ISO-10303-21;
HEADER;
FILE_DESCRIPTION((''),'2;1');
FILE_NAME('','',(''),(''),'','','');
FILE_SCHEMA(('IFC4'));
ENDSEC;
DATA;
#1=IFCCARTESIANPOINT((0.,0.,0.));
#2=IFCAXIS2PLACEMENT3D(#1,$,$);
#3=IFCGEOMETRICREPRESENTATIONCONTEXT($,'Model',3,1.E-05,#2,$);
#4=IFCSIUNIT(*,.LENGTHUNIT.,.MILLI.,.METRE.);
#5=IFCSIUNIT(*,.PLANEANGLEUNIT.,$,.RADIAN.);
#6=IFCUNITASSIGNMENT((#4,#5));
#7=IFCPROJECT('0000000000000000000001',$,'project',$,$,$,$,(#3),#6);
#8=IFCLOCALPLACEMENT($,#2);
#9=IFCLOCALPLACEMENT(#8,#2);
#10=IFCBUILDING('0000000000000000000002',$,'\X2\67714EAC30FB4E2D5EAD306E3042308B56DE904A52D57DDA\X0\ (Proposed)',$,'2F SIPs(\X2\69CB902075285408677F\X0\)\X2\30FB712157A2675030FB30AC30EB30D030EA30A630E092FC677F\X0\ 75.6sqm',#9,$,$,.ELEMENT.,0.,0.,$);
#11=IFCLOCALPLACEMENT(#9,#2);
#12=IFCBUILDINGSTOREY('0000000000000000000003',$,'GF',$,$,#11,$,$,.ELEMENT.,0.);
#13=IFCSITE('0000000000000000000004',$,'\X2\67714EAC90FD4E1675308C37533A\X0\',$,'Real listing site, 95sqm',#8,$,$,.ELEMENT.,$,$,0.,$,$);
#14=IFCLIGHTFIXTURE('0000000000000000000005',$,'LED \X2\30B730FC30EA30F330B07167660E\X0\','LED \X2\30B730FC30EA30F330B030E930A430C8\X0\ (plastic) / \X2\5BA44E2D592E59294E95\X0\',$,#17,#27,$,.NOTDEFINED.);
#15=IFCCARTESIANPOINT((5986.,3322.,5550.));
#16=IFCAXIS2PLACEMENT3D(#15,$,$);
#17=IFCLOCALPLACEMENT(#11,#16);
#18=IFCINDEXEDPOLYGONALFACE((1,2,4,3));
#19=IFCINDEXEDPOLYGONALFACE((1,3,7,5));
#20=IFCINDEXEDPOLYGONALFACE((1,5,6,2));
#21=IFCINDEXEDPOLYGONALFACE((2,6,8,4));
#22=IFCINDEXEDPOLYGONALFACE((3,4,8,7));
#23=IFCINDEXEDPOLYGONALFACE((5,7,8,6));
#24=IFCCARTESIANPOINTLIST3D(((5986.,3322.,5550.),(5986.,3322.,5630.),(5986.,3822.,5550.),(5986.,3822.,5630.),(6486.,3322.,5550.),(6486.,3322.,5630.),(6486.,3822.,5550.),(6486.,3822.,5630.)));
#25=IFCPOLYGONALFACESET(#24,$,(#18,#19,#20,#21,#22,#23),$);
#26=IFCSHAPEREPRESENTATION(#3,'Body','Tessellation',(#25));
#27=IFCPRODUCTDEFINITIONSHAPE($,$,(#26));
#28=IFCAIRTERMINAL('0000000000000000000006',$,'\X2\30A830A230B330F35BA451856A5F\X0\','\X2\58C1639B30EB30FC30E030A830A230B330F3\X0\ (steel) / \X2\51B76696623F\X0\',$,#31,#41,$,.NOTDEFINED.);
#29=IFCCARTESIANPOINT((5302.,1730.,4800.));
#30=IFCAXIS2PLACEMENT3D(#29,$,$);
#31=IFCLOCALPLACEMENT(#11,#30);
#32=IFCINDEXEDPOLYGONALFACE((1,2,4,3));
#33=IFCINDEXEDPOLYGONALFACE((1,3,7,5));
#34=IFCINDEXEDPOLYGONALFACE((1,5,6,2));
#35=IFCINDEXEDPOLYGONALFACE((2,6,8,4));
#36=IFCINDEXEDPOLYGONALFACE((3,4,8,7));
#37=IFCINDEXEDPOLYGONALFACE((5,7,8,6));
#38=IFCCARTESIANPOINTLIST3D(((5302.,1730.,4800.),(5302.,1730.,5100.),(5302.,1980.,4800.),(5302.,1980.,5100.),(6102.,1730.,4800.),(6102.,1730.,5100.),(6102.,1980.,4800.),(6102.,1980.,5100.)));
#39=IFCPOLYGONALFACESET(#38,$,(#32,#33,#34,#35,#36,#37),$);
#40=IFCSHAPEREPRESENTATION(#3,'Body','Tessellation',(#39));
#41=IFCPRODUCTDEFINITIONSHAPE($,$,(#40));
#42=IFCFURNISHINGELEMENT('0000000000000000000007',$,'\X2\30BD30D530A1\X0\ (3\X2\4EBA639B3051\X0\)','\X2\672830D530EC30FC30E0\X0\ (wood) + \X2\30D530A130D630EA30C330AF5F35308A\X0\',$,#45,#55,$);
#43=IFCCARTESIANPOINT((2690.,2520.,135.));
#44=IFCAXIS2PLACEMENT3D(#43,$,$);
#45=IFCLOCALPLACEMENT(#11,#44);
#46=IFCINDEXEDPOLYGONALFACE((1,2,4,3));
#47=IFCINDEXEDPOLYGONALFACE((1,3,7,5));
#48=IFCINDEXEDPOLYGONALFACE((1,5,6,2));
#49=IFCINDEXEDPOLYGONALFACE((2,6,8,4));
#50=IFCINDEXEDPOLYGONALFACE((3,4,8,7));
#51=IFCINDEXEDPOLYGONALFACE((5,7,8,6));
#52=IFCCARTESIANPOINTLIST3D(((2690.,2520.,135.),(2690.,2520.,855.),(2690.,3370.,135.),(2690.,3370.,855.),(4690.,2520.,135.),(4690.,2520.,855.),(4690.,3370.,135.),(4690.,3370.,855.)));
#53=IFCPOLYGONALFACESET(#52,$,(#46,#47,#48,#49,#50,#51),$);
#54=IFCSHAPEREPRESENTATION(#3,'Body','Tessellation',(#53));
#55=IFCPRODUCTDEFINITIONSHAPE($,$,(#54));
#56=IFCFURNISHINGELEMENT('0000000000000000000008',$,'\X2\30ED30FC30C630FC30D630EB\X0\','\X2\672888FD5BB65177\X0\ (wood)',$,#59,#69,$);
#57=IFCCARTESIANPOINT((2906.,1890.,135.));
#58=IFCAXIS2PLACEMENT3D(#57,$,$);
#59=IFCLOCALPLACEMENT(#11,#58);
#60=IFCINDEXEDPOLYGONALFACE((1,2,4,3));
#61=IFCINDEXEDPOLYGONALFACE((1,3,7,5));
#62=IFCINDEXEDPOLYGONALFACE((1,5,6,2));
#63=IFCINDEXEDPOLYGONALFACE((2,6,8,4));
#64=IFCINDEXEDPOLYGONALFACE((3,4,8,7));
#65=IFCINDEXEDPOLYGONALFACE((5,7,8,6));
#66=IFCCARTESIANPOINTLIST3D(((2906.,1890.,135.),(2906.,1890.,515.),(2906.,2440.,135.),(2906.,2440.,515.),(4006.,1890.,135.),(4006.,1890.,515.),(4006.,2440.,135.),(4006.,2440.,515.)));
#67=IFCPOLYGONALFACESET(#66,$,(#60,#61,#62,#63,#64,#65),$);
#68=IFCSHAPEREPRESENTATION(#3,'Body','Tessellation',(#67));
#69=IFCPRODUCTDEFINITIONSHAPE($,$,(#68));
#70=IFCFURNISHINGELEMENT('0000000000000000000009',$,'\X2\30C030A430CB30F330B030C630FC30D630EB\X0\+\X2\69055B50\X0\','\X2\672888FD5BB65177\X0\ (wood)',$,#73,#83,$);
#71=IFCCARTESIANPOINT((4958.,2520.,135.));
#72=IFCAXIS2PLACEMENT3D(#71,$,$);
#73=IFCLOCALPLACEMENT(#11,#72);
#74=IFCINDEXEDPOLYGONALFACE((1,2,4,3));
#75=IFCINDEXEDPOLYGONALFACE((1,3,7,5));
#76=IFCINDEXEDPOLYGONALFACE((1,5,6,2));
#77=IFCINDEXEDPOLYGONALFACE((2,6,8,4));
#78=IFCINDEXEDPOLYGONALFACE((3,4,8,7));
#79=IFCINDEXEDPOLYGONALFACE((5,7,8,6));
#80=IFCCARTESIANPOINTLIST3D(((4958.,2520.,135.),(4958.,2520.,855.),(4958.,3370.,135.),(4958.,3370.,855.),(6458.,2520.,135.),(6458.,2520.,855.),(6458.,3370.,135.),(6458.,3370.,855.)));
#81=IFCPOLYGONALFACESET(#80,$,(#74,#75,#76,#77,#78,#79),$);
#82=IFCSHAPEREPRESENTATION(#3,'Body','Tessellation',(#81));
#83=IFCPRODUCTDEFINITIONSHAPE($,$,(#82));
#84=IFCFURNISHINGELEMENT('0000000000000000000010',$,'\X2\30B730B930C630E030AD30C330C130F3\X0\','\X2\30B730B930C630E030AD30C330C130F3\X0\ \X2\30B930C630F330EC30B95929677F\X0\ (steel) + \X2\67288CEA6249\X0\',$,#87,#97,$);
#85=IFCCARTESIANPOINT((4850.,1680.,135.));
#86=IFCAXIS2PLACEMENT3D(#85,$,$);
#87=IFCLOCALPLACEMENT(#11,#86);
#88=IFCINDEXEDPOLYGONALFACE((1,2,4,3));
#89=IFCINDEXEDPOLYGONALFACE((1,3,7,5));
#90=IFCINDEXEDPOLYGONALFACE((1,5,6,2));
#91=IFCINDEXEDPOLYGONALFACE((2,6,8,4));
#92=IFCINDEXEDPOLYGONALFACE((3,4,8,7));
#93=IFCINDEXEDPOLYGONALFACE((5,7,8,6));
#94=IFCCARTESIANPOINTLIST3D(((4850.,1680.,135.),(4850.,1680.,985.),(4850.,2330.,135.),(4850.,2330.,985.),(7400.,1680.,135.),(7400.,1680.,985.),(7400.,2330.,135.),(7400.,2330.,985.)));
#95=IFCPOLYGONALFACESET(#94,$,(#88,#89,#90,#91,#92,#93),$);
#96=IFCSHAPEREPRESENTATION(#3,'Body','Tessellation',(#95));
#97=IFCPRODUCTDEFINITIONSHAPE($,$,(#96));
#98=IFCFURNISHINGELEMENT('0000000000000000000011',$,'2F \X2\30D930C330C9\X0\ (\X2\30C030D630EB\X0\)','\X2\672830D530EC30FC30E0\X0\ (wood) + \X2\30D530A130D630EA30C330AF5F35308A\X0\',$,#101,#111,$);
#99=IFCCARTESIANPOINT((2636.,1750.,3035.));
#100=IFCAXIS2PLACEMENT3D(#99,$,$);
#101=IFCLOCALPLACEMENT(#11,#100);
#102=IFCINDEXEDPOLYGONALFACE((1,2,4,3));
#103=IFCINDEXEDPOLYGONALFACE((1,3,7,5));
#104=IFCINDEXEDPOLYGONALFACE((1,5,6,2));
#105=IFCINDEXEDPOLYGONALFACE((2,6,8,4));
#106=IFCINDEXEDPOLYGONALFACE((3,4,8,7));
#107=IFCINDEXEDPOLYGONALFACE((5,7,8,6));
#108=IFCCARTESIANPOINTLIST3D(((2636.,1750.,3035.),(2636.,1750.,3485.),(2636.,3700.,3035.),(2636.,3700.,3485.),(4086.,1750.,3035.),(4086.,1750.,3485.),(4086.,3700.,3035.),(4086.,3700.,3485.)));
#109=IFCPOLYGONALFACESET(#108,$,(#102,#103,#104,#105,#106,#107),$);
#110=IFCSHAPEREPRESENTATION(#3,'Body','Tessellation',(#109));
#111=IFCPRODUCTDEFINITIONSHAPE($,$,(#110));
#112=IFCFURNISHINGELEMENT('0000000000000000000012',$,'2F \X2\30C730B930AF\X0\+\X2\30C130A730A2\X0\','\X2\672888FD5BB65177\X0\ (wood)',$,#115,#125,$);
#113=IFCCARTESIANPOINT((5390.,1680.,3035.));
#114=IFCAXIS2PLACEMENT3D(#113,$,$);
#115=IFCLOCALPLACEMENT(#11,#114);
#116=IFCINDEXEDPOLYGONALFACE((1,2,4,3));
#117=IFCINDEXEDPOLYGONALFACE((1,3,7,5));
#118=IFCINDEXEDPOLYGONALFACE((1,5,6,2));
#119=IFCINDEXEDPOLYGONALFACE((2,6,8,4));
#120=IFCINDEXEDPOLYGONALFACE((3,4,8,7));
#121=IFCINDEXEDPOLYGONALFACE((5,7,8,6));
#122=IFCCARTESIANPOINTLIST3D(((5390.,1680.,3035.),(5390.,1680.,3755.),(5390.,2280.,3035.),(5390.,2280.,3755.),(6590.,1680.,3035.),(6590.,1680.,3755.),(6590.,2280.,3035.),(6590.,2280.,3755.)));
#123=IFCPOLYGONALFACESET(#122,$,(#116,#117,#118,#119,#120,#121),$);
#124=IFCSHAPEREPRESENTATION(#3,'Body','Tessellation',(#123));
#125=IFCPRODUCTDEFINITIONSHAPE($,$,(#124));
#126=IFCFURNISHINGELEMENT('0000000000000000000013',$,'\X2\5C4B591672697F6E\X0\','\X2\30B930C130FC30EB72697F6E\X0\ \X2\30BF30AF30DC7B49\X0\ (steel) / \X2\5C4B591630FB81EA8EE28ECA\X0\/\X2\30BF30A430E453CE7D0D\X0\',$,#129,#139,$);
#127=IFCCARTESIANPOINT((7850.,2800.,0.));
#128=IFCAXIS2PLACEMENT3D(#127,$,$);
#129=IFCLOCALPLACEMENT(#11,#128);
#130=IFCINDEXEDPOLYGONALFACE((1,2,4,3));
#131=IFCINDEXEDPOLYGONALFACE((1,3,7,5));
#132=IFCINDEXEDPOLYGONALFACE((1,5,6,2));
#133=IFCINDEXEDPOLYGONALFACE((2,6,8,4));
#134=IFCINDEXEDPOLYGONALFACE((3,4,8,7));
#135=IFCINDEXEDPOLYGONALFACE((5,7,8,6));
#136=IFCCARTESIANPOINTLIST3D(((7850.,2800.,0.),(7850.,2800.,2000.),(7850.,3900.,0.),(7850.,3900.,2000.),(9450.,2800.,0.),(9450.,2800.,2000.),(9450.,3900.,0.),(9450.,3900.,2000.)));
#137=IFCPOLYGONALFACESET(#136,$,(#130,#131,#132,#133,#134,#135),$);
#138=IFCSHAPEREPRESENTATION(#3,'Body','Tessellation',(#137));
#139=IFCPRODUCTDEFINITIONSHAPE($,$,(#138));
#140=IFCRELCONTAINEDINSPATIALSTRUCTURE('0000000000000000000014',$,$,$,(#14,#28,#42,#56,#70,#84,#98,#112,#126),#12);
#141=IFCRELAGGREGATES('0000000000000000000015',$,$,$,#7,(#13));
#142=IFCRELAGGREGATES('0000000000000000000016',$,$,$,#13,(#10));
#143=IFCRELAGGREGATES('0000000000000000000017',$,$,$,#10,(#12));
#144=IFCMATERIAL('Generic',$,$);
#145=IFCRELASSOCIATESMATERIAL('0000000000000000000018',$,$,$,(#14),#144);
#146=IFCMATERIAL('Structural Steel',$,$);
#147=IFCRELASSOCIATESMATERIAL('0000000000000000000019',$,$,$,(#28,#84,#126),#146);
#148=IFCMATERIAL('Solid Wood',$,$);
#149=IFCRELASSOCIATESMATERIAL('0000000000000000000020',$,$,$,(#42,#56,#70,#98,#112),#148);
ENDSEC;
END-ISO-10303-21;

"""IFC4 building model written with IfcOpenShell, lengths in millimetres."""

from ifc_helpers import new_model, si_unit, frame, frame_2d, origin, place, context, project, spatial, rectangle, extrude, material, element, save


model = new_model("IFC4")

# Units and contexts
model_context = context("Model", 3, precision=1e-05, world=origin())
ifc_project = project(units=[si_unit("LENGTHUNIT", "METRE", prefix="MILLI"), si_unit("PLANEANGLEUNIT", "RADIAN")], contexts=[model_context])

# Site, building, storey
site_placement = place(None, origin())
site = spatial("IfcSite", under=ifc_project, at=site_placement, Name="東京都世田谷区", ObjectType="Real listing site, 95sqm", CompositionType="ELEMENT", RefElevation=0.0)
building_placement = place(site_placement, origin())
building = spatial("IfcBuilding", under=site, at=building_placement, Name="東京・中庭のある回遊動線 (Proposed)", ObjectType="2F SIPs(構造用合板)・無垢材・ガルバリウム鋼板 75.6sqm", CompositionType="ELEMENT", ElevationOfRefHeight=0.0, ElevationOfTerrain=0.0)
storey_placement = place(building_placement, origin())
storey = spatial("IfcBuildingStorey", under=building, at=storey_placement, Name="GF", CompositionType="ELEMENT", Elevation=0.0)

# Shared definitions
ifc_material_1 = material(Name="Solid Wood")

# Shared definitions
ifc_material_2 = material(Name="Generic")

# Shared definitions
ifc_material_3 = material(Name="Structural Steel")

# Light fixture
light_fixture_placement = place(storey_placement, frame((5986.0, 3322.0, 5550.0)))
element("IfcLightFixture", 1, at=light_fixture_placement, inside=storey, material=ifc_material_2, Name="LED シーリング照明", Description="LED シーリングライト (plastic) / 室中央天井", PredefinedType="NOTDEFINED", context=model_context, shape_type="SweptSolid", body=[
    extrude(rectangle(XDim=500.0, YDim=500.0, at=frame_2d((250.0, 250.0))), frame((5986.0, 3322.0, 5550.0)), (0.0, 0.0, 1.0), 80.0),
])

# Air terminal
air_terminal_1_placement = place(storey_placement, frame((5302.0, 1730.0, 4800.0)))
element("IfcAirTerminal", 2, at=air_terminal_1_placement, inside=storey, material=ifc_material_3, Name="エアコン室内機", Description="壁掛ルームエアコン (steel) / 冷暖房", PredefinedType="NOTDEFINED", context=model_context, shape_type="SweptSolid", body=[
    extrude(rectangle(XDim=800.0, YDim=250.0, at=frame_2d((400.0, 125.0))), frame((5302.0, 1730.0, 4800.0)), (0.0, 0.0, 1.0), 300.0),
])

# Furnishing elements
furnishing_1_placement = place(storey_placement, frame((2690.0, 2520.0, 135.0)))
element("IfcFurnishingElement", 3, at=furnishing_1_placement, inside=storey, material=ifc_material_1, Name="ソファ (3人掛け)", Description="木フレーム (wood) + ファブリック張り", context=model_context, shape_type="SweptSolid", body=[
    extrude(rectangle(XDim=2000.0, YDim=850.0, at=frame_2d((1000.0, 425.0))), frame((2690.0, 2520.0, 135.0)), (0.0, 0.0, 1.0), 720.0),
])
furnishing_2_placement = place(storey_placement, frame((2906.0, 1890.0, 135.0)))
element("IfcFurnishingElement", 4, at=furnishing_2_placement, inside=storey, material=ifc_material_1, Name="ローテーブル", Description="木製家具 (wood)", context=model_context, shape_type="SweptSolid", body=[
    extrude(rectangle(XDim=1100.0, YDim=550.0, at=frame_2d((550.0, 275.0))), frame((2906.0, 1890.0, 135.0)), (0.0, 0.0, 1.0), 380.0),
])
furnishing_3_placement = place(storey_placement, frame((4958.0, 2520.0, 135.0)))
element("IfcFurnishingElement", 5, at=furnishing_3_placement, inside=storey, material=ifc_material_1, Name="ダイニングテーブル+椅子", Description="木製家具 (wood)", context=model_context, shape_type="SweptSolid", body=[
    extrude(rectangle(XDim=1500.0, YDim=850.0, at=frame_2d((750.0, 425.0))), frame((4958.0, 2520.0, 135.0)), (0.0, 0.0, 1.0), 720.0),
])
furnishing_4_placement = place(storey_placement, frame((4850.0, 1680.0, 135.0)))
element("IfcFurnishingElement", 6, at=furnishing_4_placement, inside=storey, material=ifc_material_3, Name="システムキッチン", Description="システムキッチン ステンレス天板 (steel) + 木質扉", context=model_context, shape_type="SweptSolid", body=[
    extrude(rectangle(XDim=2550.0, YDim=650.0, at=frame_2d((1275.0, 325.0))), frame((4850.0, 1680.0, 135.0)), (0.0, 0.0, 1.0), 850.0),
])
furnishing_5_placement = place(storey_placement, frame((2636.0, 1750.0, 3035.0)))
element("IfcFurnishingElement", 7, at=furnishing_5_placement, inside=storey, material=ifc_material_1, Name="2F ベッド (ダブル)", Description="木フレーム (wood) + ファブリック張り", context=model_context, shape_type="SweptSolid", body=[
    extrude(rectangle(XDim=1450.0, YDim=1950.0, at=frame_2d((725.0, 975.0))), frame((2636.0, 1750.0, 3035.0)), (0.0, 0.0, 1.0), 450.0),
])
furnishing_6_placement = place(storey_placement, frame((5390.0, 1680.0, 3035.0)))
element("IfcFurnishingElement", 8, at=furnishing_6_placement, inside=storey, material=ifc_material_1, Name="2F デスク+チェア", Description="木製家具 (wood)", context=model_context, shape_type="SweptSolid", body=[
    extrude(rectangle(XDim=1200.0, YDim=600.0, at=frame_2d((600.0, 300.0))), frame((5390.0, 1680.0, 3035.0)), (0.0, 0.0, 1.0), 720.0),
])
furnishing_7_placement = place(storey_placement, frame((7850.0, 2800.0, 0.0)))
element("IfcFurnishingElement", 9, at=furnishing_7_placement, inside=storey, material=ifc_material_3, Name="屋外物置", Description="スチール物置 タクボ等 (steel) / 屋外・自転車/タイヤ収納", context=model_context, shape_type="SweptSolid", body=[
    extrude(rectangle(XDim=1600.0, YDim=1100.0, at=frame_2d((800.0, 550.0))), frame((7850.0, 2800.0, 0.0)), (0.0, 0.0, 1.0), 2000.0),
])

save(model, "model.ifc")
